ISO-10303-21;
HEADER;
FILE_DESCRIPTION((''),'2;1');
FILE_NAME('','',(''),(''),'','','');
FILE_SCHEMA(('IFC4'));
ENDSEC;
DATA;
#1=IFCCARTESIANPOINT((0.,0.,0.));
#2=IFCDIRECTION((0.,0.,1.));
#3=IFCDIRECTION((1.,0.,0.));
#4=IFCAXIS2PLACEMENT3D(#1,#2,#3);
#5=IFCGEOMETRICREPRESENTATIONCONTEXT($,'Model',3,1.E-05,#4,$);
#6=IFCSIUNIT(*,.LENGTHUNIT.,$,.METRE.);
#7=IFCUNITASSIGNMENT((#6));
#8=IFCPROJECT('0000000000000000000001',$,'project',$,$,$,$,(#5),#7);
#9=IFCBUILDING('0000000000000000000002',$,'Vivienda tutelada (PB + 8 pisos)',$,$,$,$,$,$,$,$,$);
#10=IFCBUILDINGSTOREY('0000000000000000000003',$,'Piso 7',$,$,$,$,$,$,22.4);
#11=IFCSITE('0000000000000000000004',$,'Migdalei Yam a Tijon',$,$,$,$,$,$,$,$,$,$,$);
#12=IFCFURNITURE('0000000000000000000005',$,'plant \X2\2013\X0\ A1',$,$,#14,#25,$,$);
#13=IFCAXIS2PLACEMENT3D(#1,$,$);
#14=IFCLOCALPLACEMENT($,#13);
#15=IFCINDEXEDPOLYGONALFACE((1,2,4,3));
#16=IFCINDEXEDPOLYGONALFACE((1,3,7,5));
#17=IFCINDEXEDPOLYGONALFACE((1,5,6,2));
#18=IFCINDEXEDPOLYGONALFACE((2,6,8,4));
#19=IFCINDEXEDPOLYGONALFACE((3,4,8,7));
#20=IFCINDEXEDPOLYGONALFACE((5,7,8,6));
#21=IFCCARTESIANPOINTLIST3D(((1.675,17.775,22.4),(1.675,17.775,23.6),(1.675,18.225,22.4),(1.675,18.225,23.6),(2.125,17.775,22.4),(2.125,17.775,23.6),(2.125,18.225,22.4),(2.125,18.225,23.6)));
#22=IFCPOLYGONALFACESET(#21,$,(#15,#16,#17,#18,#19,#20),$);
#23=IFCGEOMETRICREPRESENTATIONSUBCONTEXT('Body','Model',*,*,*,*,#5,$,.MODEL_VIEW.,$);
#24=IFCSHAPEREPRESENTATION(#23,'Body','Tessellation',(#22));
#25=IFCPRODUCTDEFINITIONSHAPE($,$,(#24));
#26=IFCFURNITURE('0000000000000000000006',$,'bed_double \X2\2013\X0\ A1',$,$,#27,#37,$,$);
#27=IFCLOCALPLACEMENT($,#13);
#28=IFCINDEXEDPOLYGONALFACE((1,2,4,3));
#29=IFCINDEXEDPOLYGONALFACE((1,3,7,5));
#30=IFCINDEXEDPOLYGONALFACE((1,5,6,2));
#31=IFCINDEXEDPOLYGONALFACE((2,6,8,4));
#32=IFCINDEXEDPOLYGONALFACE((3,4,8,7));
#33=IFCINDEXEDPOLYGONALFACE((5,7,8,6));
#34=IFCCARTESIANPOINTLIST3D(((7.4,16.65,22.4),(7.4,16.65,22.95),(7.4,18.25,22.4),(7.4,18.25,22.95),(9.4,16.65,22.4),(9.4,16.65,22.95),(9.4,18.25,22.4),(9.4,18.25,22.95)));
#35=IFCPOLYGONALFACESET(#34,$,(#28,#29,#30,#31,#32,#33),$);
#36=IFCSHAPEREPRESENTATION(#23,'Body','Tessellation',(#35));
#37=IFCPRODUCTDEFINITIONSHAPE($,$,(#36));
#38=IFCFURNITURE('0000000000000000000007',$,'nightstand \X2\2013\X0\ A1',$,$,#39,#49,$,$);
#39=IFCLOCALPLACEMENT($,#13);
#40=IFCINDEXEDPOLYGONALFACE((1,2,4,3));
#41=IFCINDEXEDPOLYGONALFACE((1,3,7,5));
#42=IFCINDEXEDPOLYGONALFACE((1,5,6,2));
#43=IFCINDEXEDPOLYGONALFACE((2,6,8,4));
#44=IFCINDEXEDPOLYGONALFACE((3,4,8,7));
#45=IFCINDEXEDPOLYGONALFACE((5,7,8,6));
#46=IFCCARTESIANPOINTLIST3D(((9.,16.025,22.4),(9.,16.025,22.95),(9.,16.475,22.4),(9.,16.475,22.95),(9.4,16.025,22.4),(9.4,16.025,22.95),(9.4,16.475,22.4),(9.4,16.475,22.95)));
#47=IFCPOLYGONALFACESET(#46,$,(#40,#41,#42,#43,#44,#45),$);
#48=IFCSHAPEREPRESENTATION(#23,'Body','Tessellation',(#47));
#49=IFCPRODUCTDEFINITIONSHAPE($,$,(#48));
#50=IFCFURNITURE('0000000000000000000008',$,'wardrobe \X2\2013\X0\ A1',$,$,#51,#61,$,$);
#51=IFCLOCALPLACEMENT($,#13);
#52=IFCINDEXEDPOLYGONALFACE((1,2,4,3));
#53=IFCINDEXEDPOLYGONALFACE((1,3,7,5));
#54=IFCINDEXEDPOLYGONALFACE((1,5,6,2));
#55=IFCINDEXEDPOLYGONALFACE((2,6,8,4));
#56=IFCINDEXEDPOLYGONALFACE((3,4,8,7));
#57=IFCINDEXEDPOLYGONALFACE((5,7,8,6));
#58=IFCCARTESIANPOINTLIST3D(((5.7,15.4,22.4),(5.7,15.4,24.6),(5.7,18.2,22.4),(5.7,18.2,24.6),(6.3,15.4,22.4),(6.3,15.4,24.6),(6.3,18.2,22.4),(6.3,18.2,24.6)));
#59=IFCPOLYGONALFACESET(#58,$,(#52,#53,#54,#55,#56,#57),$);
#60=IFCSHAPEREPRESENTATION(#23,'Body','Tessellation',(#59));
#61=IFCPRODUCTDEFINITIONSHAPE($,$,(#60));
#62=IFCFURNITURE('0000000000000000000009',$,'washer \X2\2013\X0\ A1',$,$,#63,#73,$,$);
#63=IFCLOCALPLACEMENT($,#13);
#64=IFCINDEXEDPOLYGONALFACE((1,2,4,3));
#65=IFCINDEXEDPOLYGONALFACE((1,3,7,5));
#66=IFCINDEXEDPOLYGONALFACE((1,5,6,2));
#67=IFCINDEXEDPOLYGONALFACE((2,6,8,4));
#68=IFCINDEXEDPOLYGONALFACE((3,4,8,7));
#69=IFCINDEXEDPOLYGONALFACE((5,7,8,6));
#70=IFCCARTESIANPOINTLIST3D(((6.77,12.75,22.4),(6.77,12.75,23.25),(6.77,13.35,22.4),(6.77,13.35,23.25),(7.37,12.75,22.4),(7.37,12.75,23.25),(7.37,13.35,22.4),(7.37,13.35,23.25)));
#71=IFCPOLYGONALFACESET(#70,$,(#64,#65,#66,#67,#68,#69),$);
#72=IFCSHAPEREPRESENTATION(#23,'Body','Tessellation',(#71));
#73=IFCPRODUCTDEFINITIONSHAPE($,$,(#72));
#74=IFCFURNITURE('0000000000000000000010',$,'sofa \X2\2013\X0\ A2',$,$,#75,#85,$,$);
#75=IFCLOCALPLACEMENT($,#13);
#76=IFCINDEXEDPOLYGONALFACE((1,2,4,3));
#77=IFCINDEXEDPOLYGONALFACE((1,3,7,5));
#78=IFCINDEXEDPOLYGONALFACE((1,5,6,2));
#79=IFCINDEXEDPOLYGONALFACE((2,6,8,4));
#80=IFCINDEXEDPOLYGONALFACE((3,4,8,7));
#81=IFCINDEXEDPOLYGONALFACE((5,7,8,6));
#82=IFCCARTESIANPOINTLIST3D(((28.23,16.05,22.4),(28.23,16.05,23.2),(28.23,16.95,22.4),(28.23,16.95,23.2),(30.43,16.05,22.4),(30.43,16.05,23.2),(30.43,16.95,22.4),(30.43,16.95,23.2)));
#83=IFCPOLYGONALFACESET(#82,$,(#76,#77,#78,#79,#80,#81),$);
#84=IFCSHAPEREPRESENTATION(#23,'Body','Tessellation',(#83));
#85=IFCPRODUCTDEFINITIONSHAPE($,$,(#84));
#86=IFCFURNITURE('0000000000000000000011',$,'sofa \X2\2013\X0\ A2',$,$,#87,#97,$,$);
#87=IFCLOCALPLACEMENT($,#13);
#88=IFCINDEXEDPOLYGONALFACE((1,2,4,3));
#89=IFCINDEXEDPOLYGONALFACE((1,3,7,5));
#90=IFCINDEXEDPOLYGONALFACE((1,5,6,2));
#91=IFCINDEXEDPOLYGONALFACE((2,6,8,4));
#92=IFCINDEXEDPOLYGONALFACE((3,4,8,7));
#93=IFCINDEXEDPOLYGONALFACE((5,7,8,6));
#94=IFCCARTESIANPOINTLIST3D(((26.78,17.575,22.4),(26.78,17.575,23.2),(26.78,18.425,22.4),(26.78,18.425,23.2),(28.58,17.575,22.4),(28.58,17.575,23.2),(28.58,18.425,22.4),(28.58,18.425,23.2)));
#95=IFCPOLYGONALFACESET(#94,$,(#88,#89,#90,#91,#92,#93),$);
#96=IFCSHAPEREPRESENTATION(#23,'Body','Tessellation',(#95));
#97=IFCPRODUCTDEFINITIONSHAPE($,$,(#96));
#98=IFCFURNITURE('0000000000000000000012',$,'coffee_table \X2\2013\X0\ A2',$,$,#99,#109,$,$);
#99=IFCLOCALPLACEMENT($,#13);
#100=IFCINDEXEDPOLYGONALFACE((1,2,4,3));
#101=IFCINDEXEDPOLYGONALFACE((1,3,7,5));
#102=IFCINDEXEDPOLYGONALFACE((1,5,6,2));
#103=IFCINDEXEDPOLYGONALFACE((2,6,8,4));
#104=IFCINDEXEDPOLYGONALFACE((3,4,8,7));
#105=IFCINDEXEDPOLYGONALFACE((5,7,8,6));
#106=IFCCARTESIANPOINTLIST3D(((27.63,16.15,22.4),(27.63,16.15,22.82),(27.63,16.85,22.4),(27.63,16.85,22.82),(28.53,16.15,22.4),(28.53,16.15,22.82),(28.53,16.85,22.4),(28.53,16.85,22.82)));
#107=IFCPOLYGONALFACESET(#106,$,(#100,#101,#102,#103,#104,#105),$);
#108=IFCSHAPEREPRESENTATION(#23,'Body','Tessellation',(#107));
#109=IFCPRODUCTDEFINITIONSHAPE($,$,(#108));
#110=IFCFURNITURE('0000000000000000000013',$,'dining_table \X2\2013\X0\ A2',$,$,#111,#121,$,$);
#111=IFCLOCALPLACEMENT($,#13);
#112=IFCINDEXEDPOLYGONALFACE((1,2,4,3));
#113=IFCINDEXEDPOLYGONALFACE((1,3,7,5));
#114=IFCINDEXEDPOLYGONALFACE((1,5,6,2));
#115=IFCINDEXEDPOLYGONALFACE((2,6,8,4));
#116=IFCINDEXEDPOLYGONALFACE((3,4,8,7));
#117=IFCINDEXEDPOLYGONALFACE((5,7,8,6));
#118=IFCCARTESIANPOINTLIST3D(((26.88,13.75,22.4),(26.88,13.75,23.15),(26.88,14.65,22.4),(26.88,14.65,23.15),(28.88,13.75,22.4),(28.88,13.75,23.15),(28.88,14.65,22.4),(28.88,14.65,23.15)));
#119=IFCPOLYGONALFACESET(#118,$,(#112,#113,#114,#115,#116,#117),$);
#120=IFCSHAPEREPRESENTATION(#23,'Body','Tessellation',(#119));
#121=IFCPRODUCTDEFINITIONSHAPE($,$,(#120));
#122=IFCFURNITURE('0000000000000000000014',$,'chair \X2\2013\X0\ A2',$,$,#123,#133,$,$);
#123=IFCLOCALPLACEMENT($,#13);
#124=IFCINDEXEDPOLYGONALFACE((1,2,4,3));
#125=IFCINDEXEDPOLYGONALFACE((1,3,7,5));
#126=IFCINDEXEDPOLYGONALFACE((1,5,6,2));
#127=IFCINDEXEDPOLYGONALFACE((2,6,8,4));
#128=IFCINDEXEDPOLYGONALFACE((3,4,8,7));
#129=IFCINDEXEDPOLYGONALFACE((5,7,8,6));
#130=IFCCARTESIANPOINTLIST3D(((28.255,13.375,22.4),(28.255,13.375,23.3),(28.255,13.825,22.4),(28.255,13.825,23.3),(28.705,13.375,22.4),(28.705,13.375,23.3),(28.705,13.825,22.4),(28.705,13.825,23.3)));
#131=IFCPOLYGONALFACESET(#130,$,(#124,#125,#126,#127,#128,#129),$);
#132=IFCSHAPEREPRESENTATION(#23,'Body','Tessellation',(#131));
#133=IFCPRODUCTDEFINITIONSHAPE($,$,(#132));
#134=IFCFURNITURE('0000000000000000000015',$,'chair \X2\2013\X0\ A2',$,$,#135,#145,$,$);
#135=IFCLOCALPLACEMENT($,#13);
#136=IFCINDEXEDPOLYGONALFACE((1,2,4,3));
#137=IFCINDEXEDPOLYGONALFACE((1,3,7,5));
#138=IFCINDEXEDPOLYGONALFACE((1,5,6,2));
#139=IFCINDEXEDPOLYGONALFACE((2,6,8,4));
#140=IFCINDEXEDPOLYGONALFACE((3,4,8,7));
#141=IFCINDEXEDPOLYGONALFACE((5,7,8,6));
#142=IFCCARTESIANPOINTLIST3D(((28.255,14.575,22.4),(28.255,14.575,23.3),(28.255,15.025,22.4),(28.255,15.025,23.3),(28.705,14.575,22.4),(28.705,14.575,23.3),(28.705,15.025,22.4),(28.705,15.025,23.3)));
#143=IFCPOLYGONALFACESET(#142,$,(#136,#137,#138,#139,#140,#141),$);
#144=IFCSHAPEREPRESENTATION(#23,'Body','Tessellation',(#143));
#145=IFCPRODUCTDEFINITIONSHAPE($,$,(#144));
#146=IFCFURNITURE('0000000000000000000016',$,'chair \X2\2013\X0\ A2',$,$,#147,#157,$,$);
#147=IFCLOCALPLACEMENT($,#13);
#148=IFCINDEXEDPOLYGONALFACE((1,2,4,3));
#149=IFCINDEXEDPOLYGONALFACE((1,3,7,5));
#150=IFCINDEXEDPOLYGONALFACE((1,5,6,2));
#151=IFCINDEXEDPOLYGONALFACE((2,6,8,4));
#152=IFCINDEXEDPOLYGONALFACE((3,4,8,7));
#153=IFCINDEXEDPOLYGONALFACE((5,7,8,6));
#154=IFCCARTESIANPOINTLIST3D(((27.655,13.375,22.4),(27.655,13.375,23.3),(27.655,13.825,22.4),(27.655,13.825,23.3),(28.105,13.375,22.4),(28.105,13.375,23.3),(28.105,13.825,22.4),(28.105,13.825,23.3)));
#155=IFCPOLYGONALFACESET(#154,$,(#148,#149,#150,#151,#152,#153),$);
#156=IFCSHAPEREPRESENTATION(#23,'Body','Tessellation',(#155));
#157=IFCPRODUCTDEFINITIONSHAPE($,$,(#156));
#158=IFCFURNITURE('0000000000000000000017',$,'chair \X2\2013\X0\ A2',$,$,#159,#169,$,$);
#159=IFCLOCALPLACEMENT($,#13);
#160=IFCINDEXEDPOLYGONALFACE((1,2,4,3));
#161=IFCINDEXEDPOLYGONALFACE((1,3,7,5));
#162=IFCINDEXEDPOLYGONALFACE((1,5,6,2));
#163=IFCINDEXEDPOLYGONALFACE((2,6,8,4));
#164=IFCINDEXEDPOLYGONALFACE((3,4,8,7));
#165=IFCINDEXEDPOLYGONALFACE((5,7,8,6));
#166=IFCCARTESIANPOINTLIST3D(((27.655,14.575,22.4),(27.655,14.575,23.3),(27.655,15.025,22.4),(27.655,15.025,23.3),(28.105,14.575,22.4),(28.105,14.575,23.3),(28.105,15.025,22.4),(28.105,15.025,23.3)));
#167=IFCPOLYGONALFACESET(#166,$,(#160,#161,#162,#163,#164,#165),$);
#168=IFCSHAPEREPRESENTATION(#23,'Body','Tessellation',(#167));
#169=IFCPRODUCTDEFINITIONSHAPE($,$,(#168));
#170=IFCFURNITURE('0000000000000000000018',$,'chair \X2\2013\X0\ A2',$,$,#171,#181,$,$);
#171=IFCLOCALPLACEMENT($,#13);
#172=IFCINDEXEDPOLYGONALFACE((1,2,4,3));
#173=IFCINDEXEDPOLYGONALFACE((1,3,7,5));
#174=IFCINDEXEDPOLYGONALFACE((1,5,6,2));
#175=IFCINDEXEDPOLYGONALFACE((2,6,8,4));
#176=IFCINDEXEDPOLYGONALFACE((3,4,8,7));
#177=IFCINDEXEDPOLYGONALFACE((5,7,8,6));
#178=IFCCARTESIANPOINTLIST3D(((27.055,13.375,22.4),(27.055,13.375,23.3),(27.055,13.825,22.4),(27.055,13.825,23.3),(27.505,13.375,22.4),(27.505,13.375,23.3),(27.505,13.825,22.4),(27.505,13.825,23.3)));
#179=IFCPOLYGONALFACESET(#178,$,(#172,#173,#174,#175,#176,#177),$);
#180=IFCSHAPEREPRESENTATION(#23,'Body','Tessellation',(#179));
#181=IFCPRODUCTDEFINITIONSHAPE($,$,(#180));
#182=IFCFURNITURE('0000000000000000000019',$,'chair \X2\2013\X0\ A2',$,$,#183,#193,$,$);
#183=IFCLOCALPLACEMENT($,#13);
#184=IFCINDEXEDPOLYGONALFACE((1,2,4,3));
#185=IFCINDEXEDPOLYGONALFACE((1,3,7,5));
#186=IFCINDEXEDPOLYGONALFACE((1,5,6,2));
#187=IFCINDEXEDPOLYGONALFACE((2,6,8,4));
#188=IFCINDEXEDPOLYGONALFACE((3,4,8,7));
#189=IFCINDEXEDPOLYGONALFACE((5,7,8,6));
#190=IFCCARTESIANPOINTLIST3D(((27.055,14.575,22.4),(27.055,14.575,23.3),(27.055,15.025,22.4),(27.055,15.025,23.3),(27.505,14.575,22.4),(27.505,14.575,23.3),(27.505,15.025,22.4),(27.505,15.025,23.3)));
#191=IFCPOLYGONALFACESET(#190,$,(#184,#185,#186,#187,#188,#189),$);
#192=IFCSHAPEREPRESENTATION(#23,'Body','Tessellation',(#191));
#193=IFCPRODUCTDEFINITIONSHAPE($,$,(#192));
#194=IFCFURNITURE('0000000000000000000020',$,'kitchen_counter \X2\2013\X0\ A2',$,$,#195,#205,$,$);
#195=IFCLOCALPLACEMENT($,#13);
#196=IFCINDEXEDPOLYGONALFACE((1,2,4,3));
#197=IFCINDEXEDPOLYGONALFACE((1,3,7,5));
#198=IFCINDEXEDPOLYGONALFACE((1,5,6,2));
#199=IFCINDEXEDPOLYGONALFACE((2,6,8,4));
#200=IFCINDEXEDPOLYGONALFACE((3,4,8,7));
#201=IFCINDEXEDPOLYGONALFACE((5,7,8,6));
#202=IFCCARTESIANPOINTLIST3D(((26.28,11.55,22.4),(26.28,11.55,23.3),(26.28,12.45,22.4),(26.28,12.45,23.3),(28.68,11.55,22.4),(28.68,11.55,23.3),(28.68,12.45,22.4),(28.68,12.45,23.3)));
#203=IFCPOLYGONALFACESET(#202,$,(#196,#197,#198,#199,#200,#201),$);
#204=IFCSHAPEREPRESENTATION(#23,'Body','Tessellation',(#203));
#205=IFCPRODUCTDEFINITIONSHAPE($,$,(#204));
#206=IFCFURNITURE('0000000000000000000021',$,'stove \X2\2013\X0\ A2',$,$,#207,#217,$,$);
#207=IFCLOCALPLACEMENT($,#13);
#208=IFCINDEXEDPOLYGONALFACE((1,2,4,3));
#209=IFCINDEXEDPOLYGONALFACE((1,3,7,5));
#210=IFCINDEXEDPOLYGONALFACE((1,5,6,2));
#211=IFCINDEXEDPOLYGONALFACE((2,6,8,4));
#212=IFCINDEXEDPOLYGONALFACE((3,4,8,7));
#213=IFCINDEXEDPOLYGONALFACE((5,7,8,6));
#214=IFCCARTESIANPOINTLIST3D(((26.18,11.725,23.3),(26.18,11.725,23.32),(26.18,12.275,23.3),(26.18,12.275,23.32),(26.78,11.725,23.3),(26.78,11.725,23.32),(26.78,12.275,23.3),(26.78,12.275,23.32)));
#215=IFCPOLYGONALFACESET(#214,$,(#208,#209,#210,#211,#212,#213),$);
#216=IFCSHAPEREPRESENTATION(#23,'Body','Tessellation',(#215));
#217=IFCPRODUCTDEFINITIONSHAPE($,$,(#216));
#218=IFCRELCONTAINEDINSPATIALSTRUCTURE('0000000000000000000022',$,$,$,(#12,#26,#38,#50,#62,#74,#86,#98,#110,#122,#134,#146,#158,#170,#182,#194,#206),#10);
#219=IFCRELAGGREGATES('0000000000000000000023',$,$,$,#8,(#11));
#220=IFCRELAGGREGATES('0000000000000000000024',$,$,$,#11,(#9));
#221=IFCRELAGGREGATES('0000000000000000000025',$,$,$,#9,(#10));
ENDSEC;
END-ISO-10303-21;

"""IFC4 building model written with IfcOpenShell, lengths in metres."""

from ifc_helpers import new_model, si_unit, frame, origin_with_axes, context, subcontext, project, spatial, line, indexed_curve, outline, extrude, element, save


model = new_model("IFC4")

# Units and contexts
model_context = context("Model", 3, precision=1e-05, world=origin_with_axes())
body_context = subcontext(model_context, "Body", "Model", "MODEL_VIEW")
ifc_project = project(units=[si_unit("LENGTHUNIT", "METRE")], contexts=[model_context])

# Site, building, storey
site = spatial("IfcSite", under=ifc_project, Name="Migdalei Yam a Tijon")
building = spatial("IfcBuilding", under=site, Name="Vivienda tutelada (PB + 8 pisos)")
storey = spatial("IfcBuildingStorey", under=building, Name="Piso 7", Elevation=22.4)

# Furniture
element("IfcFurniture", 1, inside=storey, Name="plant – A1", context=body_context, shape_type="SweptSolid", body=[
    extrude(outline(indexed_curve([(0.0, 0.0), (0.45, 0.0), (0.45, 0.45), (0.0, 0.45)], segments=[line(1, 2, 3, 4, 1)])), frame((1.675, 17.775, 22.4), z_axis=(0.0, 0.0, 1.0), x_axis=(1.0, 0.0, 0.0)), (0.0, 0.0, 1.0), 1.2),
])
element("IfcFurniture", 2, inside=storey, Name="bed_double – A1", context=body_context, shape_type="SweptSolid", body=[
    extrude(outline(indexed_curve([(0.0, 0.0), (2.0, 0.0), (2.0, 1.6), (0.0, 1.6)], segments=[line(1, 2, 3, 4, 1)])), frame((7.4, 16.65, 22.4), z_axis=(0.0, 0.0, 1.0), x_axis=(1.0, 0.0, 0.0)), (0.0, 0.0, 1.0), 0.55),
])
element("IfcFurniture", 3, inside=storey, Name="nightstand – A1", context=body_context, shape_type="SweptSolid", body=[
    extrude(outline(indexed_curve([(0.0, 0.0), (0.4, 0.0), (0.4, 0.45), (0.0, 0.45)], segments=[line(1, 2, 3, 4, 1)])), frame((9.0, 16.025, 22.4), z_axis=(0.0, 0.0, 1.0), x_axis=(1.0, 0.0, 0.0)), (0.0, 0.0, 1.0), 0.55),
])
element("IfcFurniture", 4, inside=storey, Name="wardrobe – A1", context=body_context, shape_type="SweptSolid", body=[
    extrude(outline(indexed_curve([(0.0, 0.0), (0.6, 0.0), (0.6, 2.8), (0.0, 2.8)], segments=[line(1, 2, 3, 4, 1)])), frame((5.7, 15.4, 22.4), z_axis=(0.0, 0.0, 1.0), x_axis=(1.0, 0.0, 0.0)), (0.0, 0.0, 1.0), 2.2),
])
element("IfcFurniture", 5, inside=storey, Name="washer – A1", context=body_context, shape_type="SweptSolid", body=[
    extrude(outline(indexed_curve([(0.0, 0.0), (0.6, 0.0), (0.6, 0.6), (0.0, 0.6)], segments=[line(1, 2, 3, 4, 1)])), frame((6.77, 12.75, 22.4), z_axis=(0.0, 0.0, 1.0), x_axis=(1.0, 0.0, 0.0)), (0.0, 0.0, 1.0), 0.85),
])
element("IfcFurniture", 6, inside=storey, Name="sofa – A2", context=body_context, shape_type="SweptSolid", body=[
    extrude(outline(indexed_curve([(0.0, 0.0), (2.2, 0.0), (2.2, 0.9), (0.0, 0.9)], segments=[line(1, 2, 3, 4, 1)])), frame((28.23, 16.05, 22.4), z_axis=(0.0, 0.0, 1.0), x_axis=(1.0, 0.0, 0.0)), (0.0, 0.0, 1.0), 0.8),
])
element("IfcFurniture", 7, inside=storey, Name="sofa – A2", context=body_context, shape_type="SweptSolid", body=[
    extrude(outline(indexed_curve([(0.0, 0.0), (1.8, 0.0), (1.8, 0.85), (0.0, 0.85)], segments=[line(1, 2, 3, 4, 1)])), frame((26.78, 17.575, 22.4), z_axis=(0.0, 0.0, 1.0), x_axis=(1.0, 0.0, 0.0)), (0.0, 0.0, 1.0), 0.8),
])
element("IfcFurniture", 8, inside=storey, Name="coffee_table – A2", context=body_context, shape_type="SweptSolid", body=[
    extrude(outline(indexed_curve([(0.0, 0.0), (0.9, 0.0), (0.9, 0.7), (0.0, 0.7)], segments=[line(1, 2, 3, 4, 1)])), frame((27.63, 16.15, 22.4), z_axis=(0.0, 0.0, 1.0), x_axis=(1.0, 0.0, 0.0)), (0.0, 0.0, 1.0), 0.42),
])
element("IfcFurniture", 9, inside=storey, Name="dining_table – A2", context=body_context, shape_type="SweptSolid", body=[
    extrude(outline(indexed_curve([(0.0, 0.0), (2.0, 0.0), (2.0, 0.9), (0.0, 0.9)], segments=[line(1, 2, 3, 4, 1)])), frame((26.88, 13.75, 22.4), z_axis=(0.0, 0.0, 1.0), x_axis=(1.0, 0.0, 0.0)), (0.0, 0.0, 1.0), 0.75),
])
element("IfcFurniture", 10, inside=storey, Name="chair – A2", context=body_context, shape_type="SweptSolid", body=[
    extrude(outline(indexed_curve([(0.0, 0.0), (0.45, 0.0), (0.45, 0.45), (0.0, 0.45)], segments=[line(1, 2, 3, 4, 1)])), frame((28.255, 13.375, 22.4), z_axis=(0.0, 0.0, 1.0), x_axis=(1.0, 0.0, 0.0)), (0.0, 0.0, 1.0), 0.9),
])
element("IfcFurniture", 11, inside=storey, Name="chair – A2", context=body_context, shape_type="SweptSolid", body=[
    extrude(outline(indexed_curve([(0.0, 0.0), (0.45, 0.0), (0.45, 0.45), (0.0, 0.45)], segments=[line(1, 2, 3, 4, 1)])), frame((28.255, 14.575, 22.4), z_axis=(0.0, 0.0, 1.0), x_axis=(1.0, 0.0, 0.0)), (0.0, 0.0, 1.0), 0.9),
])
element("IfcFurniture", 12, inside=storey, Name="chair – A2", context=body_context, shape_type="SweptSolid", body=[
    extrude(outline(indexed_curve([(0.0, 0.0), (0.45, 0.0), (0.45, 0.45), (0.0, 0.45)], segments=[line(1, 2, 3, 4, 1)])), frame((27.655, 13.375, 22.4), z_axis=(0.0, 0.0, 1.0), x_axis=(1.0, 0.0, 0.0)), (0.0, 0.0, 1.0), 0.9),
])
element("IfcFurniture", 13, inside=storey, Name="chair – A2", context=body_context, shape_type="SweptSolid", body=[
    extrude(outline(indexed_curve([(0.0, 0.0), (0.45, 0.0), (0.45, 0.45), (0.0, 0.45)], segments=[line(1, 2, 3, 4, 1)])), frame((27.655, 14.575, 22.4), z_axis=(0.0, 0.0, 1.0), x_axis=(1.0, 0.0, 0.0)), (0.0, 0.0, 1.0), 0.9),
])
element("IfcFurniture", 14, inside=storey, Name="chair – A2", context=body_context, shape_type="SweptSolid", body=[
    extrude(outline(indexed_curve([(0.0, 0.0), (0.45, 0.0), (0.45, 0.45), (0.0, 0.45)], segments=[line(1, 2, 3, 4, 1)])), frame((27.055, 13.375, 22.4), z_axis=(0.0, 0.0, 1.0), x_axis=(1.0, 0.0, 0.0)), (0.0, 0.0, 1.0), 0.9),
])
element("IfcFurniture", 15, inside=storey, Name="chair – A2", context=body_context, shape_type="SweptSolid", body=[
    extrude(outline(indexed_curve([(0.0, 0.0), (0.45, 0.0), (0.45, 0.45), (0.0, 0.45)], segments=[line(1, 2, 3, 4, 1)])), frame((27.055, 14.575, 22.4), z_axis=(0.0, 0.0, 1.0), x_axis=(1.0, 0.0, 0.0)), (0.0, 0.0, 1.0), 0.9),
])
element("IfcFurniture", 16, inside=storey, Name="kitchen_counter – A2", context=body_context, shape_type="SweptSolid", body=[
    extrude(outline(indexed_curve([(0.0, 0.0), (2.4, 0.0), (2.4, 0.9), (0.0, 0.9)], segments=[line(1, 2, 3, 4, 1)])), frame((26.28, 11.55, 22.4), z_axis=(0.0, 0.0, 1.0), x_axis=(1.0, 0.0, 0.0)), (0.0, 0.0, 1.0), 0.9),
])
element("IfcFurniture", 17, inside=storey, Name="stove – A2", context=body_context, shape_type="SweptSolid", body=[
    extrude(outline(indexed_curve([(0.0, 0.0), (0.6, 0.0), (0.6, 0.55), (0.0, 0.55)], segments=[line(1, 2, 3, 4, 1)])), frame((26.18, 11.725, 23.3), z_axis=(0.0, 0.0, 1.0), x_axis=(1.0, 0.0, 0.0)), (0.0, 0.0, 1.0), 0.02),
])

save(model, "model.ifc")
